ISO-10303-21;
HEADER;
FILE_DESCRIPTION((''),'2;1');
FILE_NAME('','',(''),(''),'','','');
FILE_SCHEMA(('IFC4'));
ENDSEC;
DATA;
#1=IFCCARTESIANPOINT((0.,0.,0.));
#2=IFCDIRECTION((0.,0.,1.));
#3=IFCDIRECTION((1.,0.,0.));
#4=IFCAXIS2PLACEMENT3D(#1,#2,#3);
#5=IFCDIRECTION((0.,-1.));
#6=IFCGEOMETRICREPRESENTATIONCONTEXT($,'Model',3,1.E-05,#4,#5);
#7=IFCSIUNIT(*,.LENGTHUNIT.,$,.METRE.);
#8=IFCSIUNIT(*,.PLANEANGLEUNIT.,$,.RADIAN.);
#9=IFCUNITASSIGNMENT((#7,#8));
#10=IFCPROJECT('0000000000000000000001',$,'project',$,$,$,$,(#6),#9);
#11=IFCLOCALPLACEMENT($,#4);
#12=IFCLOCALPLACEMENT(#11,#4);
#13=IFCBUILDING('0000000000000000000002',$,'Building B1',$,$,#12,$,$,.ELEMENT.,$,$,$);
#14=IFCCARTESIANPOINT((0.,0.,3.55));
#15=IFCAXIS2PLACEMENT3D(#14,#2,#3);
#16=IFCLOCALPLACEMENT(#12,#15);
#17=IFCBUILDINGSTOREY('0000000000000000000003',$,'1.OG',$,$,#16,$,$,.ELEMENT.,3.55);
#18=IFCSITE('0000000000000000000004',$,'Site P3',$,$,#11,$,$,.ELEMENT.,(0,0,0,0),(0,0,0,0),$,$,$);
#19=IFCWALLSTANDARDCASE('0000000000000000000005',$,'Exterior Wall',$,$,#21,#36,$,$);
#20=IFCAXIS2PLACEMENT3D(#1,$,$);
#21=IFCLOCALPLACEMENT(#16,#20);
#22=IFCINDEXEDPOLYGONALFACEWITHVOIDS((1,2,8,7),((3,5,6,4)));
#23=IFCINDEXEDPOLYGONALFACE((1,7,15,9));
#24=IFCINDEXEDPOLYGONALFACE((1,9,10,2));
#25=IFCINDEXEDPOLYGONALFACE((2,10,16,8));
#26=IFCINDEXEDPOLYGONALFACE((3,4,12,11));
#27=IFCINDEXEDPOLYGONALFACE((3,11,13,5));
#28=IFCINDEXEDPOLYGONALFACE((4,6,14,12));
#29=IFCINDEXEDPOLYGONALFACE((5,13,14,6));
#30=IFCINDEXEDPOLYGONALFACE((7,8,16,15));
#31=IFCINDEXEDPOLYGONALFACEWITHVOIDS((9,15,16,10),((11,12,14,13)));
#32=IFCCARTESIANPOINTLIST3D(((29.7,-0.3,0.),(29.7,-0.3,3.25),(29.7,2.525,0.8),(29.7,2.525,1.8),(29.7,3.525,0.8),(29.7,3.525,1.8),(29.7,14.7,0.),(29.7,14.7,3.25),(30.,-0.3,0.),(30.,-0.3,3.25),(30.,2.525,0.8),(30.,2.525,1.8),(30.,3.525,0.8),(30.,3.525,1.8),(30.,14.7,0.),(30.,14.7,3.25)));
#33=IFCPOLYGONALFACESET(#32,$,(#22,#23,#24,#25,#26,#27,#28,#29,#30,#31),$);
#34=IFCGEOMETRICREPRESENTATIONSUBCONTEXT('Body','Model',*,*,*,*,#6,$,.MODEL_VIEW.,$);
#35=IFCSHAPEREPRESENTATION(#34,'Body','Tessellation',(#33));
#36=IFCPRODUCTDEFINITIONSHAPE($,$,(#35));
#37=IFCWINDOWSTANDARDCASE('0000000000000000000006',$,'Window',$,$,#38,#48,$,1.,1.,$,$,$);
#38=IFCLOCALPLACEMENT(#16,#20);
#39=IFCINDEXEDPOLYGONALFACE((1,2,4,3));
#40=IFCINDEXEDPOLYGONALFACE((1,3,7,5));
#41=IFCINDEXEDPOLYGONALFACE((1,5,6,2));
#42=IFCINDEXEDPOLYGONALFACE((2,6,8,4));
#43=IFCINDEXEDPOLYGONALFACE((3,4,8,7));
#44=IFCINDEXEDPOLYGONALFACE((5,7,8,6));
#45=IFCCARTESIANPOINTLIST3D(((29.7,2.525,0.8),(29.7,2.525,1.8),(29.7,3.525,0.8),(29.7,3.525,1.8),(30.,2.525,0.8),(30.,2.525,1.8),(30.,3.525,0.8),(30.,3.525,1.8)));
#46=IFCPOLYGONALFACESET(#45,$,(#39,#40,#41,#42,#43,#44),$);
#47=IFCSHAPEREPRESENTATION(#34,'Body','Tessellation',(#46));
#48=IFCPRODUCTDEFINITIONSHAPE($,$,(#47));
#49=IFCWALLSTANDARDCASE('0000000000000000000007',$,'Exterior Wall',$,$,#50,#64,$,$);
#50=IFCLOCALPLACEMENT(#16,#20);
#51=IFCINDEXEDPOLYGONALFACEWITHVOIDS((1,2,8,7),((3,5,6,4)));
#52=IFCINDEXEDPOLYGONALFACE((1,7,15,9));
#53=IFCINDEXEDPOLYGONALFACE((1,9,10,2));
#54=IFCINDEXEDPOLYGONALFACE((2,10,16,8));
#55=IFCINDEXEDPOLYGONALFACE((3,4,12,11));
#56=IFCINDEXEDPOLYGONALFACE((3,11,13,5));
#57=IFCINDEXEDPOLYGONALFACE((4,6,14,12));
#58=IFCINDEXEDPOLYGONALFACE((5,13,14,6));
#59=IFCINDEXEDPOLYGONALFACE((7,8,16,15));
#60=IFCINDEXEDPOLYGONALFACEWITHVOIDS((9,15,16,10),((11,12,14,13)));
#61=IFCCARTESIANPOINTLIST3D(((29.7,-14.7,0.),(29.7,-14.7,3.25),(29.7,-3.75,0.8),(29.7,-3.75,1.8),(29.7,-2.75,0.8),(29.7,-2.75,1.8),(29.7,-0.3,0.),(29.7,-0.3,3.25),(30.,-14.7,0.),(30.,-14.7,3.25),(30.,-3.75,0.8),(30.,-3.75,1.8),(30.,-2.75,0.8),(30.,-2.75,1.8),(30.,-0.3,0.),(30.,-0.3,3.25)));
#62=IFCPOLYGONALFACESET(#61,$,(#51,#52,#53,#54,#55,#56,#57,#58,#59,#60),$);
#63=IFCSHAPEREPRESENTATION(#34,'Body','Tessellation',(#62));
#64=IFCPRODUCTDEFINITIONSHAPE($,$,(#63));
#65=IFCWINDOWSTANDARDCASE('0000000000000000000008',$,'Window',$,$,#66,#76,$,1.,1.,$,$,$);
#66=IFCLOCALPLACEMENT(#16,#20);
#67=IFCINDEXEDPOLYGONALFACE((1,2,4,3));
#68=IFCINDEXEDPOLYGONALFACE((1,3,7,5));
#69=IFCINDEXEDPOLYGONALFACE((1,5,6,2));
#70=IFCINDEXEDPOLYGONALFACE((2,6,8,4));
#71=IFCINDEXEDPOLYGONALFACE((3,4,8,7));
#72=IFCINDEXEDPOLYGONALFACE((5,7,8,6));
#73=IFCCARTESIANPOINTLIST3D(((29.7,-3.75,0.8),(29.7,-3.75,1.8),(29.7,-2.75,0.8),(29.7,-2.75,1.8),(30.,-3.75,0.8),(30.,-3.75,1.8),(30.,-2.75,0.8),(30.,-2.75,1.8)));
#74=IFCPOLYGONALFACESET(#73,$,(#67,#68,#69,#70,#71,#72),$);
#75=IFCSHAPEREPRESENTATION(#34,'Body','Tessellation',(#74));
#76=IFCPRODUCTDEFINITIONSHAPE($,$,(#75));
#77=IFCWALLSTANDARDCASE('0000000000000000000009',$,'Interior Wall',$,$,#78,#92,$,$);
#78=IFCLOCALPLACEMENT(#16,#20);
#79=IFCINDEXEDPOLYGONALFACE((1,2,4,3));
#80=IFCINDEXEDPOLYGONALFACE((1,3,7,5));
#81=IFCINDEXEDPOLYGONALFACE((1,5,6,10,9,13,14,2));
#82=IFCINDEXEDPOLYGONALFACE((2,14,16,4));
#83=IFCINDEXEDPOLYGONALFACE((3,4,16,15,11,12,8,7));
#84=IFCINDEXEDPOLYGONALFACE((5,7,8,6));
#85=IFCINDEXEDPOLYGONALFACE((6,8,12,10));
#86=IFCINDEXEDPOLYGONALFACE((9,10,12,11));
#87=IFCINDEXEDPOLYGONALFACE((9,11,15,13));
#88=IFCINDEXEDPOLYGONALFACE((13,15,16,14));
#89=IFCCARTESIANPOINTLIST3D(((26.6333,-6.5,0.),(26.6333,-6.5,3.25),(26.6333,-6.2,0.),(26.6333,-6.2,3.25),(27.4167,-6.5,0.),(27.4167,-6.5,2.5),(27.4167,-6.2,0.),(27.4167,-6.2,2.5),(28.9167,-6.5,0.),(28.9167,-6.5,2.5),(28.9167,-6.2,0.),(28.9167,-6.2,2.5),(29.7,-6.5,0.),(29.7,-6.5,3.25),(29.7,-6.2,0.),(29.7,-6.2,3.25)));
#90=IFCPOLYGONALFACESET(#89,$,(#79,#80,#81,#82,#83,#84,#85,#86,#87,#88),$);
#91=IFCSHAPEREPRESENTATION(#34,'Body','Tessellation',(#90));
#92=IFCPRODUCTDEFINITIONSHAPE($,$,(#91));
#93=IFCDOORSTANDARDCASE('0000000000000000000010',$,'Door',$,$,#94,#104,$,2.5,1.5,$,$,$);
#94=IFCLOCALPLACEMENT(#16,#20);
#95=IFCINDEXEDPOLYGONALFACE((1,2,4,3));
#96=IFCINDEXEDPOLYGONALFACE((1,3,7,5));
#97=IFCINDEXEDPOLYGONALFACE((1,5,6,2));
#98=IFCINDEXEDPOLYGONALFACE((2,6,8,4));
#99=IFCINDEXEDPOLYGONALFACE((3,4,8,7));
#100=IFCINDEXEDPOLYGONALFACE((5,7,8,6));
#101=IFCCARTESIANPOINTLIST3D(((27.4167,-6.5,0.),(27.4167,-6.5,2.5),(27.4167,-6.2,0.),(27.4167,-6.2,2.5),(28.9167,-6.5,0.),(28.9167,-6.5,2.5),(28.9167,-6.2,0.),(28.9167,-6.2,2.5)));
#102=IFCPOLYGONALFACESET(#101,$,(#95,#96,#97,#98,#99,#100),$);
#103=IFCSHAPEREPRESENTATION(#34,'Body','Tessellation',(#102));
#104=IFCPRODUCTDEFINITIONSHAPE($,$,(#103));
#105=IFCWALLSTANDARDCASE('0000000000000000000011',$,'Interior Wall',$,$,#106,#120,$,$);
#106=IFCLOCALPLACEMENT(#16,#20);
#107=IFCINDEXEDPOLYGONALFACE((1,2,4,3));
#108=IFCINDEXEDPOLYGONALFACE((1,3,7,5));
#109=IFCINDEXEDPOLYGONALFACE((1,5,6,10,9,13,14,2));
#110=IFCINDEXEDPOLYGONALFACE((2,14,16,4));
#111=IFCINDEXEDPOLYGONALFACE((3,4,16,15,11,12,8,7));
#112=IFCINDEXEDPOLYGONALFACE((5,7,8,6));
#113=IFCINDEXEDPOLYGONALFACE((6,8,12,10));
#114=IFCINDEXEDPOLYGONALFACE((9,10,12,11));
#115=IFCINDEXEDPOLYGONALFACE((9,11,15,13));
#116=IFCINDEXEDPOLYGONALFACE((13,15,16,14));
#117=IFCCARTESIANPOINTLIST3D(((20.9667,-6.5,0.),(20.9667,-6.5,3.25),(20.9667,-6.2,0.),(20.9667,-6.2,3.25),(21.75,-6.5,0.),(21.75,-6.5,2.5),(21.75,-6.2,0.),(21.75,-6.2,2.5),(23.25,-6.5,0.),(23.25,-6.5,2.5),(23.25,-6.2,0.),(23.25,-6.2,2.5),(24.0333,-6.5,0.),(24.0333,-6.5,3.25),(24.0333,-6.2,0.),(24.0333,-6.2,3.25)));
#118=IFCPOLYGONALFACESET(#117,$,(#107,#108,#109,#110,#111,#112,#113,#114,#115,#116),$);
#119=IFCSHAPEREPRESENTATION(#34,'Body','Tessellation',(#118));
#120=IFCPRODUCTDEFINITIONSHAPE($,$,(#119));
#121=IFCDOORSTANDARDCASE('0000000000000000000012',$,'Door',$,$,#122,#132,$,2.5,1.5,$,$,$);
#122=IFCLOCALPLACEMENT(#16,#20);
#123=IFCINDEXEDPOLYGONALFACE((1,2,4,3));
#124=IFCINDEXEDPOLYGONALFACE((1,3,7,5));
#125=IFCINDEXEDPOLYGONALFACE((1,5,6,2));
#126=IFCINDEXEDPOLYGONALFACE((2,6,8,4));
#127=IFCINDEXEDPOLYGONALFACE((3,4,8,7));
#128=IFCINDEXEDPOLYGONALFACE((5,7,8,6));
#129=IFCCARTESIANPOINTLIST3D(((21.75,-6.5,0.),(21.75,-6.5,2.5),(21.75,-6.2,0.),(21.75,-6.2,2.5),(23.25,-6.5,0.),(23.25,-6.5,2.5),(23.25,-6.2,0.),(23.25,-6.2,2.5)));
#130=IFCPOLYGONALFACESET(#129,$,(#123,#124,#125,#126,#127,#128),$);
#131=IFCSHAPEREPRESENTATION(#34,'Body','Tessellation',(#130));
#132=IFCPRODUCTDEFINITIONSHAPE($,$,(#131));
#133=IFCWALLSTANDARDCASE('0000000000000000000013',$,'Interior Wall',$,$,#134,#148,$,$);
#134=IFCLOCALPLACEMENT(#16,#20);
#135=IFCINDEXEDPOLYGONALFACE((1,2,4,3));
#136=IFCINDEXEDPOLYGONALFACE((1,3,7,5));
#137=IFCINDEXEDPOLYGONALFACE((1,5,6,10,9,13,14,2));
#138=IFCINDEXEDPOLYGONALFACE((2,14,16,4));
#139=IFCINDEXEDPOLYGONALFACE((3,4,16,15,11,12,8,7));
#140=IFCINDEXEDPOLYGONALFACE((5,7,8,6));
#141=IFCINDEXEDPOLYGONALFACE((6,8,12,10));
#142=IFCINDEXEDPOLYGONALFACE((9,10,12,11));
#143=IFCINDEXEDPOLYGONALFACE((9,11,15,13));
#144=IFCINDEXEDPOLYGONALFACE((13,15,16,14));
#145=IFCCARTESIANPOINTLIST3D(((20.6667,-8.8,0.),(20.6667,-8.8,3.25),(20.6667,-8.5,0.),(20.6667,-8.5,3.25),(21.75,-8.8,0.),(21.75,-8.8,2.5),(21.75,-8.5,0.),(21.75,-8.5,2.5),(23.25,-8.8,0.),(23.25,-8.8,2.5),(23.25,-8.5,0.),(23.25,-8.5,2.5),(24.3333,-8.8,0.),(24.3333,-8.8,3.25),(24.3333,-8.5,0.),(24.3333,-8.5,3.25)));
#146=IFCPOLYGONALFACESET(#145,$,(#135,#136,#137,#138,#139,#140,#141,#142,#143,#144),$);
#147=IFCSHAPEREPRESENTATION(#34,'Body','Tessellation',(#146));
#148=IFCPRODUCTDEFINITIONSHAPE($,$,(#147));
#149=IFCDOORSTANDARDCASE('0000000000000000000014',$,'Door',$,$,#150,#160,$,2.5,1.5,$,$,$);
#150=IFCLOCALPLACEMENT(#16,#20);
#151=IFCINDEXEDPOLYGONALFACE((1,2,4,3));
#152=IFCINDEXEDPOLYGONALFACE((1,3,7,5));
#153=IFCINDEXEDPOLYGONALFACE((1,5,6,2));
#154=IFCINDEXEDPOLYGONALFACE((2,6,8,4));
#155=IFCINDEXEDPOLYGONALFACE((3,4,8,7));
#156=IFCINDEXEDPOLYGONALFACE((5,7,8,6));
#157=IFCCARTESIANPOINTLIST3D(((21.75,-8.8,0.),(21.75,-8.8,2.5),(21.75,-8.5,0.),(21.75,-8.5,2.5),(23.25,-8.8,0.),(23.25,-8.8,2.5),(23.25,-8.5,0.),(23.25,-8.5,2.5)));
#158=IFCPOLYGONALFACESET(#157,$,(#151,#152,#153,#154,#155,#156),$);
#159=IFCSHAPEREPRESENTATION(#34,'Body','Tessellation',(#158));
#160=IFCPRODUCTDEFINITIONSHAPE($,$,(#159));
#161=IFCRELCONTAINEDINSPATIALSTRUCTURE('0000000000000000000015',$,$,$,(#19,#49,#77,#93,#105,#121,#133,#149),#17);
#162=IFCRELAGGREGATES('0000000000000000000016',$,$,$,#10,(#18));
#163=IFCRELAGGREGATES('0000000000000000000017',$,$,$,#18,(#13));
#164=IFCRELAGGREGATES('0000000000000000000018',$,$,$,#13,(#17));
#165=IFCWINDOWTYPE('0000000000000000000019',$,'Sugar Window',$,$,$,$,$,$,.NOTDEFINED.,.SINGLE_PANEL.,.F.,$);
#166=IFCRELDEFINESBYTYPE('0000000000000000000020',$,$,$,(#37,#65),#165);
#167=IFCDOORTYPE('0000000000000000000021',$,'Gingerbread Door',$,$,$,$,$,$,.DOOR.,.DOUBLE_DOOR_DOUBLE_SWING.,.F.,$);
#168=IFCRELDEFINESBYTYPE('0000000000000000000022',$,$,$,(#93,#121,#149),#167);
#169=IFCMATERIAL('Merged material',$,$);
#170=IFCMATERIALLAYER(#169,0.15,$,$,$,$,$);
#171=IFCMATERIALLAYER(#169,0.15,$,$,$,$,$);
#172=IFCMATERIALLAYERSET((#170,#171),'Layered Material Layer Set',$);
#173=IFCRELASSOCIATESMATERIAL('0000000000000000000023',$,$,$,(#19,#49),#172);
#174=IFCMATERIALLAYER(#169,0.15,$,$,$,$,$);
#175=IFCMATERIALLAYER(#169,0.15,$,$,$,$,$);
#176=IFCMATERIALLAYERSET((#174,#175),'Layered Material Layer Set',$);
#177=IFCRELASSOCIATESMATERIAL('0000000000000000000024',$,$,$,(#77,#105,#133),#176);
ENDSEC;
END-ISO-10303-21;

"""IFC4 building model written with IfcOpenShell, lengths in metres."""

from ifc_helpers import new_model, si_unit, direction, frame, origin_with_axes, place, context, subcontext, project, spatial, polyline, outline, extrude, source, transform, mapped, material, layer, layer_set, layer_usage, type_object, element, fill, save


model = new_model("IFC4")

# Units and contexts
model_context = context("Model", 3, precision=1e-05, world=origin_with_axes(), true_north=direction((0.0, -1.0)))
body_context = subcontext(model_context, "Body", "Model", "MODEL_VIEW")
ifc_project = project(units=[si_unit("LENGTHUNIT", "METRE"), si_unit("PLANEANGLEUNIT", "RADIAN")], contexts=[model_context])

# Site, building, storey
site_placement = place(None, origin_with_axes())
site = spatial("IfcSite", under=ifc_project, at=site_placement, Name="Site P3", CompositionType="ELEMENT", RefLatitude=(0, 0, 0, 0), RefLongitude=(0, 0, 0, 0))
building_placement = place(site_placement, origin_with_axes())
building = spatial("IfcBuilding", under=site, at=building_placement, Name="Building B1", CompositionType="ELEMENT")
storey_placement = place(building_placement, frame((0.0, 0.0, 3.55), z_axis=(0.0, 0.0, 1.0), x_axis=(1.0, 0.0, 0.0)))
storey = spatial("IfcBuildingStorey", under=building, at=storey_placement, Name="1.OG", CompositionType="ELEMENT", Elevation=3.55)

# Walls, openings, windows
ifc_material = material(Name="Merged material")
ifc_layer_1 = layer(ifc_material, 0.15)
ifc_layer_2 = layer(ifc_material, 0.15)
ifc_layer_set_1 = layer_set([ifc_layer_1, ifc_layer_2], Name="Layered Material Layer Set")
ifc_layer_usage_1 = layer_usage(ifc_layer_set_1, "AXIS2", "POSITIVE", -0.15)
wall_1_placement = place(storey_placement, frame((29.85, -0.3, 0.0), z_axis=(0.0, 0.0, 1.0), x_axis=(0.0, 1.0, 0.0)))
wall_1 = element("IfcWallStandardCase", 1, at=wall_1_placement, inside=storey, material=ifc_layer_usage_1, Name="Exterior Wall", context=body_context, shape_type="SweptSolid", body=[
    extrude(outline(polyline([(0.0, 0.15), (15.0, 0.15), (15.0, -0.15), (0.0, -0.15), (0.0, 0.15)])), origin_with_axes(), (0.0, 0.0, 1.0), 3.25),
])
opening_1_placement = place(wall_1_placement, frame((2.825, 0.0, 0.8), z_axis=(0.0, 0.0, 1.0), x_axis=(1.0, 0.0, 0.0)))
opening_1 = element("IfcOpeningStandardCase", 2, at=opening_1_placement, cuts=wall_1, context=body_context, shape_type="SweptSolid", body=[
    extrude(outline(polyline([(0.0, 0.0), (0.0, 1.0), (1.0, 1.0), (1.0, 0.0), (0.0, 0.0)])), frame((0.0, -0.15, 0.0), z_axis=(0.0, 1.0, 0.0), x_axis=(0.0, 0.0, 1.0)), (0.0, 0.0, 1.0), 0.3),
])
window_type = type_object("IfcWindowType", Name="Sugar Window", ParameterTakesPrecedence=False, PartitioningType="SINGLE_PANEL", PredefinedType="NOTDEFINED")
shared_shape_1 = source(origin_with_axes(), body_context, "Body", "SweptSolid", [
    extrude(outline(polyline([(0.0, 0.0), (0.0, 1.0), (1.0, 1.0), (1.0, 0.0), (0.0, 0.0)])), frame((0.0, -0.15, 0.0), z_axis=(0.0, 1.0, 0.0), x_axis=(0.0, 0.0, 1.0)), (0.0, 0.0, 1.0), 0.3),
])
window_1_placement = place(opening_1_placement, origin_with_axes())
window_1 = element("IfcWindowStandardCase", 3, at=window_1_placement, type_object=window_type, Name="Window", OverallHeight=1.0, OverallWidth=1.0, context=body_context, shape_type="MappedRepresentation", body=[
    mapped(shared_shape_1, transform((0.0, 0.0, 0.0))),
])
fill(opening_1, window_1)
wall_2_placement = place(storey_placement, frame((29.85, -14.7, 0.0), z_axis=(0.0, 0.0, 1.0), x_axis=(0.0, 1.0, 0.0)))
wall_2 = element("IfcWallStandardCase", 4, at=wall_2_placement, inside=storey, material=ifc_layer_usage_1, Name="Exterior Wall", context=body_context, shape_type="SweptSolid", body=[
    extrude(outline(polyline([(0.0, 0.15), (14.4, 0.15), (14.4, -0.15), (0.0, -0.15), (0.0, 0.15)])), origin_with_axes(), (0.0, 0.0, 1.0), 3.25),
])
opening_2_placement = place(wall_2_placement, frame((10.95, 0.0, 0.8), z_axis=(0.0, 0.0, 1.0), x_axis=(1.0, 0.0, 0.0)))
opening_2 = element("IfcOpeningStandardCase", 5, at=opening_2_placement, cuts=wall_2, context=body_context, shape_type="SweptSolid", body=[
    extrude(outline(polyline([(0.0, 0.0), (0.0, 1.0), (1.0, 1.0), (1.0, 0.0), (0.0, 0.0)])), frame((0.0, -0.15, 0.0), z_axis=(0.0, 1.0, 0.0), x_axis=(0.0, 0.0, 1.0)), (0.0, 0.0, 1.0), 0.3),
])
window_2_placement = place(opening_2_placement, origin_with_axes())
window_2 = element("IfcWindowStandardCase", 6, at=window_2_placement, type_object=window_type, Name="Window", OverallHeight=1.0, OverallWidth=1.0, context=body_context, shape_type="MappedRepresentation", body=[
    mapped(shared_shape_1, transform((0.0, 0.0, 0.0))),
])
fill(opening_2, window_2)

# Walls, openings, doors
ifc_layer_3 = layer(ifc_material, 0.15)
ifc_layer_4 = layer(ifc_material, 0.15)
ifc_layer_set_2 = layer_set([ifc_layer_3, ifc_layer_4], Name="Layered Material Layer Set")
ifc_layer_usage_2 = layer_usage(ifc_layer_set_2, "AXIS2", "POSITIVE", -0.15)
wall_3_placement = place(storey_placement, frame((26.6333, -6.35, 0.0), z_axis=(0.0, 0.0, 1.0), x_axis=(1.0, 0.0, 0.0)))
wall_3 = element("IfcWallStandardCase", 7, at=wall_3_placement, inside=storey, material=ifc_layer_usage_2, Name="Interior Wall", context=body_context, shape_type="SweptSolid", body=[
    extrude(outline(polyline([(0.0, 0.15), (3.0667, 0.15), (3.0667, -0.15), (0.0, -0.15), (0.0, 0.15)])), origin_with_axes(), (0.0, 0.0, 1.0), 3.25),
])
opening_3_placement = place(wall_3_placement, frame((0.7833, 0.0, 0.0), z_axis=(0.0, 0.0, 1.0), x_axis=(1.0, 0.0, 0.0)))
opening_3 = element("IfcOpeningStandardCase", 8, at=opening_3_placement, cuts=wall_3, context=body_context, shape_type="SweptSolid", body=[
    extrude(outline(polyline([(0.0, 0.0), (0.0, 1.5), (2.5, 1.5), (2.5, 0.0), (0.0, 0.0)])), frame((0.0, -0.15, 0.0), z_axis=(0.0, 1.0, 0.0), x_axis=(0.0, 0.0, 1.0)), (0.0, 0.0, 1.0), 0.3),
])
door_type = type_object("IfcDoorType", Name="Gingerbread Door", OperationType="DOUBLE_DOOR_DOUBLE_SWING", ParameterTakesPrecedence=False, PredefinedType="DOOR")
shared_shape_2 = source(origin_with_axes(), body_context, "Body", "SweptSolid", [
    extrude(outline(polyline([(0.0, 0.0), (0.0, 1.5), (2.5, 1.5), (2.5, 0.0), (0.0, 0.0)])), frame((0.0, -0.15, 0.0), z_axis=(0.0, 1.0, 0.0), x_axis=(0.0, 0.0, 1.0)), (0.0, 0.0, 1.0), 0.3),
])
door_1_placement = place(opening_3_placement, origin_with_axes())
door_1 = element("IfcDoorStandardCase", 9, at=door_1_placement, inside=storey, type_object=door_type, Name="Door", OverallHeight=2.5, OverallWidth=1.5, context=body_context, shape_type="MappedRepresentation", body=[
    mapped(shared_shape_2, transform((0.0, 0.0, 0.0))),
])
fill(opening_3, door_1)
wall_4_placement = place(storey_placement, frame((20.9667, -6.35, 0.0), z_axis=(0.0, 0.0, 1.0), x_axis=(1.0, 0.0, 0.0)))
wall_4 = element("IfcWallStandardCase", 10, at=wall_4_placement, inside=storey, material=ifc_layer_usage_2, Name="Interior Wall", context=body_context, shape_type="SweptSolid", body=[
    extrude(outline(polyline([(0.0, 0.15), (3.0667, 0.15), (3.0667, -0.15), (0.0, -0.15), (0.0, 0.15)])), origin_with_axes(), (0.0, 0.0, 1.0), 3.25),
])
opening_4_placement = place(wall_4_placement, frame((0.7833, 0.0, 0.0), z_axis=(0.0, 0.0, 1.0), x_axis=(1.0, 0.0, 0.0)))
opening_4 = element("IfcOpeningStandardCase", 11, at=opening_4_placement, cuts=wall_4, context=body_context, shape_type="SweptSolid", body=[
    extrude(outline(polyline([(0.0, 0.0), (0.0, 1.5), (2.5, 1.5), (2.5, 0.0), (0.0, 0.0)])), frame((0.0, -0.15, 0.0), z_axis=(0.0, 1.0, 0.0), x_axis=(0.0, 0.0, 1.0)), (0.0, 0.0, 1.0), 0.3),
])
door_2_placement = place(opening_4_placement, origin_with_axes())
door_2 = element("IfcDoorStandardCase", 12, at=door_2_placement, inside=storey, type_object=door_type, Name="Door", OverallHeight=2.5, OverallWidth=1.5, context=body_context, shape_type="MappedRepresentation", body=[
    mapped(shared_shape_2, transform((0.0, 0.0, 0.0))),
])
fill(opening_4, door_2)
wall_5_placement = place(storey_placement, frame((20.6667, -8.65, 0.0), z_axis=(0.0, 0.0, 1.0), x_axis=(1.0, 0.0, 0.0)))
wall_5 = element("IfcWallStandardCase", 13, at=wall_5_placement, inside=storey, material=ifc_layer_usage_2, Name="Interior Wall", context=body_context, shape_type="SweptSolid", body=[
    extrude(outline(polyline([(0.0, 0.15), (3.6667, 0.15), (3.6667, -0.15), (0.0, -0.15), (0.0, 0.15)])), origin_with_axes(), (0.0, 0.0, 1.0), 3.25),
])
opening_5_placement = place(wall_5_placement, frame((1.0833, 0.0, 0.0), z_axis=(0.0, 0.0, 1.0), x_axis=(1.0, 0.0, 0.0)))
opening_5 = element("IfcOpeningStandardCase", 14, at=opening_5_placement, cuts=wall_5, context=body_context, shape_type="SweptSolid", body=[
    extrude(outline(polyline([(0.0, 0.0), (0.0, 1.5), (2.5, 1.5), (2.5, 0.0), (0.0, 0.0)])), frame((0.0, -0.15, 0.0), z_axis=(0.0, 1.0, 0.0), x_axis=(0.0, 0.0, 1.0)), (0.0, 0.0, 1.0), 0.3),
])
door_3_placement = place(opening_5_placement, origin_with_axes())
door_3 = element("IfcDoorStandardCase", 15, at=door_3_placement, inside=storey, type_object=door_type, Name="Door", OverallHeight=2.5, OverallWidth=1.5, context=body_context, shape_type="MappedRepresentation", body=[
    mapped(shared_shape_2, transform((0.0, 0.0, 0.0))),
])
fill(opening_5, door_3)

save(model, "model.ifc")
